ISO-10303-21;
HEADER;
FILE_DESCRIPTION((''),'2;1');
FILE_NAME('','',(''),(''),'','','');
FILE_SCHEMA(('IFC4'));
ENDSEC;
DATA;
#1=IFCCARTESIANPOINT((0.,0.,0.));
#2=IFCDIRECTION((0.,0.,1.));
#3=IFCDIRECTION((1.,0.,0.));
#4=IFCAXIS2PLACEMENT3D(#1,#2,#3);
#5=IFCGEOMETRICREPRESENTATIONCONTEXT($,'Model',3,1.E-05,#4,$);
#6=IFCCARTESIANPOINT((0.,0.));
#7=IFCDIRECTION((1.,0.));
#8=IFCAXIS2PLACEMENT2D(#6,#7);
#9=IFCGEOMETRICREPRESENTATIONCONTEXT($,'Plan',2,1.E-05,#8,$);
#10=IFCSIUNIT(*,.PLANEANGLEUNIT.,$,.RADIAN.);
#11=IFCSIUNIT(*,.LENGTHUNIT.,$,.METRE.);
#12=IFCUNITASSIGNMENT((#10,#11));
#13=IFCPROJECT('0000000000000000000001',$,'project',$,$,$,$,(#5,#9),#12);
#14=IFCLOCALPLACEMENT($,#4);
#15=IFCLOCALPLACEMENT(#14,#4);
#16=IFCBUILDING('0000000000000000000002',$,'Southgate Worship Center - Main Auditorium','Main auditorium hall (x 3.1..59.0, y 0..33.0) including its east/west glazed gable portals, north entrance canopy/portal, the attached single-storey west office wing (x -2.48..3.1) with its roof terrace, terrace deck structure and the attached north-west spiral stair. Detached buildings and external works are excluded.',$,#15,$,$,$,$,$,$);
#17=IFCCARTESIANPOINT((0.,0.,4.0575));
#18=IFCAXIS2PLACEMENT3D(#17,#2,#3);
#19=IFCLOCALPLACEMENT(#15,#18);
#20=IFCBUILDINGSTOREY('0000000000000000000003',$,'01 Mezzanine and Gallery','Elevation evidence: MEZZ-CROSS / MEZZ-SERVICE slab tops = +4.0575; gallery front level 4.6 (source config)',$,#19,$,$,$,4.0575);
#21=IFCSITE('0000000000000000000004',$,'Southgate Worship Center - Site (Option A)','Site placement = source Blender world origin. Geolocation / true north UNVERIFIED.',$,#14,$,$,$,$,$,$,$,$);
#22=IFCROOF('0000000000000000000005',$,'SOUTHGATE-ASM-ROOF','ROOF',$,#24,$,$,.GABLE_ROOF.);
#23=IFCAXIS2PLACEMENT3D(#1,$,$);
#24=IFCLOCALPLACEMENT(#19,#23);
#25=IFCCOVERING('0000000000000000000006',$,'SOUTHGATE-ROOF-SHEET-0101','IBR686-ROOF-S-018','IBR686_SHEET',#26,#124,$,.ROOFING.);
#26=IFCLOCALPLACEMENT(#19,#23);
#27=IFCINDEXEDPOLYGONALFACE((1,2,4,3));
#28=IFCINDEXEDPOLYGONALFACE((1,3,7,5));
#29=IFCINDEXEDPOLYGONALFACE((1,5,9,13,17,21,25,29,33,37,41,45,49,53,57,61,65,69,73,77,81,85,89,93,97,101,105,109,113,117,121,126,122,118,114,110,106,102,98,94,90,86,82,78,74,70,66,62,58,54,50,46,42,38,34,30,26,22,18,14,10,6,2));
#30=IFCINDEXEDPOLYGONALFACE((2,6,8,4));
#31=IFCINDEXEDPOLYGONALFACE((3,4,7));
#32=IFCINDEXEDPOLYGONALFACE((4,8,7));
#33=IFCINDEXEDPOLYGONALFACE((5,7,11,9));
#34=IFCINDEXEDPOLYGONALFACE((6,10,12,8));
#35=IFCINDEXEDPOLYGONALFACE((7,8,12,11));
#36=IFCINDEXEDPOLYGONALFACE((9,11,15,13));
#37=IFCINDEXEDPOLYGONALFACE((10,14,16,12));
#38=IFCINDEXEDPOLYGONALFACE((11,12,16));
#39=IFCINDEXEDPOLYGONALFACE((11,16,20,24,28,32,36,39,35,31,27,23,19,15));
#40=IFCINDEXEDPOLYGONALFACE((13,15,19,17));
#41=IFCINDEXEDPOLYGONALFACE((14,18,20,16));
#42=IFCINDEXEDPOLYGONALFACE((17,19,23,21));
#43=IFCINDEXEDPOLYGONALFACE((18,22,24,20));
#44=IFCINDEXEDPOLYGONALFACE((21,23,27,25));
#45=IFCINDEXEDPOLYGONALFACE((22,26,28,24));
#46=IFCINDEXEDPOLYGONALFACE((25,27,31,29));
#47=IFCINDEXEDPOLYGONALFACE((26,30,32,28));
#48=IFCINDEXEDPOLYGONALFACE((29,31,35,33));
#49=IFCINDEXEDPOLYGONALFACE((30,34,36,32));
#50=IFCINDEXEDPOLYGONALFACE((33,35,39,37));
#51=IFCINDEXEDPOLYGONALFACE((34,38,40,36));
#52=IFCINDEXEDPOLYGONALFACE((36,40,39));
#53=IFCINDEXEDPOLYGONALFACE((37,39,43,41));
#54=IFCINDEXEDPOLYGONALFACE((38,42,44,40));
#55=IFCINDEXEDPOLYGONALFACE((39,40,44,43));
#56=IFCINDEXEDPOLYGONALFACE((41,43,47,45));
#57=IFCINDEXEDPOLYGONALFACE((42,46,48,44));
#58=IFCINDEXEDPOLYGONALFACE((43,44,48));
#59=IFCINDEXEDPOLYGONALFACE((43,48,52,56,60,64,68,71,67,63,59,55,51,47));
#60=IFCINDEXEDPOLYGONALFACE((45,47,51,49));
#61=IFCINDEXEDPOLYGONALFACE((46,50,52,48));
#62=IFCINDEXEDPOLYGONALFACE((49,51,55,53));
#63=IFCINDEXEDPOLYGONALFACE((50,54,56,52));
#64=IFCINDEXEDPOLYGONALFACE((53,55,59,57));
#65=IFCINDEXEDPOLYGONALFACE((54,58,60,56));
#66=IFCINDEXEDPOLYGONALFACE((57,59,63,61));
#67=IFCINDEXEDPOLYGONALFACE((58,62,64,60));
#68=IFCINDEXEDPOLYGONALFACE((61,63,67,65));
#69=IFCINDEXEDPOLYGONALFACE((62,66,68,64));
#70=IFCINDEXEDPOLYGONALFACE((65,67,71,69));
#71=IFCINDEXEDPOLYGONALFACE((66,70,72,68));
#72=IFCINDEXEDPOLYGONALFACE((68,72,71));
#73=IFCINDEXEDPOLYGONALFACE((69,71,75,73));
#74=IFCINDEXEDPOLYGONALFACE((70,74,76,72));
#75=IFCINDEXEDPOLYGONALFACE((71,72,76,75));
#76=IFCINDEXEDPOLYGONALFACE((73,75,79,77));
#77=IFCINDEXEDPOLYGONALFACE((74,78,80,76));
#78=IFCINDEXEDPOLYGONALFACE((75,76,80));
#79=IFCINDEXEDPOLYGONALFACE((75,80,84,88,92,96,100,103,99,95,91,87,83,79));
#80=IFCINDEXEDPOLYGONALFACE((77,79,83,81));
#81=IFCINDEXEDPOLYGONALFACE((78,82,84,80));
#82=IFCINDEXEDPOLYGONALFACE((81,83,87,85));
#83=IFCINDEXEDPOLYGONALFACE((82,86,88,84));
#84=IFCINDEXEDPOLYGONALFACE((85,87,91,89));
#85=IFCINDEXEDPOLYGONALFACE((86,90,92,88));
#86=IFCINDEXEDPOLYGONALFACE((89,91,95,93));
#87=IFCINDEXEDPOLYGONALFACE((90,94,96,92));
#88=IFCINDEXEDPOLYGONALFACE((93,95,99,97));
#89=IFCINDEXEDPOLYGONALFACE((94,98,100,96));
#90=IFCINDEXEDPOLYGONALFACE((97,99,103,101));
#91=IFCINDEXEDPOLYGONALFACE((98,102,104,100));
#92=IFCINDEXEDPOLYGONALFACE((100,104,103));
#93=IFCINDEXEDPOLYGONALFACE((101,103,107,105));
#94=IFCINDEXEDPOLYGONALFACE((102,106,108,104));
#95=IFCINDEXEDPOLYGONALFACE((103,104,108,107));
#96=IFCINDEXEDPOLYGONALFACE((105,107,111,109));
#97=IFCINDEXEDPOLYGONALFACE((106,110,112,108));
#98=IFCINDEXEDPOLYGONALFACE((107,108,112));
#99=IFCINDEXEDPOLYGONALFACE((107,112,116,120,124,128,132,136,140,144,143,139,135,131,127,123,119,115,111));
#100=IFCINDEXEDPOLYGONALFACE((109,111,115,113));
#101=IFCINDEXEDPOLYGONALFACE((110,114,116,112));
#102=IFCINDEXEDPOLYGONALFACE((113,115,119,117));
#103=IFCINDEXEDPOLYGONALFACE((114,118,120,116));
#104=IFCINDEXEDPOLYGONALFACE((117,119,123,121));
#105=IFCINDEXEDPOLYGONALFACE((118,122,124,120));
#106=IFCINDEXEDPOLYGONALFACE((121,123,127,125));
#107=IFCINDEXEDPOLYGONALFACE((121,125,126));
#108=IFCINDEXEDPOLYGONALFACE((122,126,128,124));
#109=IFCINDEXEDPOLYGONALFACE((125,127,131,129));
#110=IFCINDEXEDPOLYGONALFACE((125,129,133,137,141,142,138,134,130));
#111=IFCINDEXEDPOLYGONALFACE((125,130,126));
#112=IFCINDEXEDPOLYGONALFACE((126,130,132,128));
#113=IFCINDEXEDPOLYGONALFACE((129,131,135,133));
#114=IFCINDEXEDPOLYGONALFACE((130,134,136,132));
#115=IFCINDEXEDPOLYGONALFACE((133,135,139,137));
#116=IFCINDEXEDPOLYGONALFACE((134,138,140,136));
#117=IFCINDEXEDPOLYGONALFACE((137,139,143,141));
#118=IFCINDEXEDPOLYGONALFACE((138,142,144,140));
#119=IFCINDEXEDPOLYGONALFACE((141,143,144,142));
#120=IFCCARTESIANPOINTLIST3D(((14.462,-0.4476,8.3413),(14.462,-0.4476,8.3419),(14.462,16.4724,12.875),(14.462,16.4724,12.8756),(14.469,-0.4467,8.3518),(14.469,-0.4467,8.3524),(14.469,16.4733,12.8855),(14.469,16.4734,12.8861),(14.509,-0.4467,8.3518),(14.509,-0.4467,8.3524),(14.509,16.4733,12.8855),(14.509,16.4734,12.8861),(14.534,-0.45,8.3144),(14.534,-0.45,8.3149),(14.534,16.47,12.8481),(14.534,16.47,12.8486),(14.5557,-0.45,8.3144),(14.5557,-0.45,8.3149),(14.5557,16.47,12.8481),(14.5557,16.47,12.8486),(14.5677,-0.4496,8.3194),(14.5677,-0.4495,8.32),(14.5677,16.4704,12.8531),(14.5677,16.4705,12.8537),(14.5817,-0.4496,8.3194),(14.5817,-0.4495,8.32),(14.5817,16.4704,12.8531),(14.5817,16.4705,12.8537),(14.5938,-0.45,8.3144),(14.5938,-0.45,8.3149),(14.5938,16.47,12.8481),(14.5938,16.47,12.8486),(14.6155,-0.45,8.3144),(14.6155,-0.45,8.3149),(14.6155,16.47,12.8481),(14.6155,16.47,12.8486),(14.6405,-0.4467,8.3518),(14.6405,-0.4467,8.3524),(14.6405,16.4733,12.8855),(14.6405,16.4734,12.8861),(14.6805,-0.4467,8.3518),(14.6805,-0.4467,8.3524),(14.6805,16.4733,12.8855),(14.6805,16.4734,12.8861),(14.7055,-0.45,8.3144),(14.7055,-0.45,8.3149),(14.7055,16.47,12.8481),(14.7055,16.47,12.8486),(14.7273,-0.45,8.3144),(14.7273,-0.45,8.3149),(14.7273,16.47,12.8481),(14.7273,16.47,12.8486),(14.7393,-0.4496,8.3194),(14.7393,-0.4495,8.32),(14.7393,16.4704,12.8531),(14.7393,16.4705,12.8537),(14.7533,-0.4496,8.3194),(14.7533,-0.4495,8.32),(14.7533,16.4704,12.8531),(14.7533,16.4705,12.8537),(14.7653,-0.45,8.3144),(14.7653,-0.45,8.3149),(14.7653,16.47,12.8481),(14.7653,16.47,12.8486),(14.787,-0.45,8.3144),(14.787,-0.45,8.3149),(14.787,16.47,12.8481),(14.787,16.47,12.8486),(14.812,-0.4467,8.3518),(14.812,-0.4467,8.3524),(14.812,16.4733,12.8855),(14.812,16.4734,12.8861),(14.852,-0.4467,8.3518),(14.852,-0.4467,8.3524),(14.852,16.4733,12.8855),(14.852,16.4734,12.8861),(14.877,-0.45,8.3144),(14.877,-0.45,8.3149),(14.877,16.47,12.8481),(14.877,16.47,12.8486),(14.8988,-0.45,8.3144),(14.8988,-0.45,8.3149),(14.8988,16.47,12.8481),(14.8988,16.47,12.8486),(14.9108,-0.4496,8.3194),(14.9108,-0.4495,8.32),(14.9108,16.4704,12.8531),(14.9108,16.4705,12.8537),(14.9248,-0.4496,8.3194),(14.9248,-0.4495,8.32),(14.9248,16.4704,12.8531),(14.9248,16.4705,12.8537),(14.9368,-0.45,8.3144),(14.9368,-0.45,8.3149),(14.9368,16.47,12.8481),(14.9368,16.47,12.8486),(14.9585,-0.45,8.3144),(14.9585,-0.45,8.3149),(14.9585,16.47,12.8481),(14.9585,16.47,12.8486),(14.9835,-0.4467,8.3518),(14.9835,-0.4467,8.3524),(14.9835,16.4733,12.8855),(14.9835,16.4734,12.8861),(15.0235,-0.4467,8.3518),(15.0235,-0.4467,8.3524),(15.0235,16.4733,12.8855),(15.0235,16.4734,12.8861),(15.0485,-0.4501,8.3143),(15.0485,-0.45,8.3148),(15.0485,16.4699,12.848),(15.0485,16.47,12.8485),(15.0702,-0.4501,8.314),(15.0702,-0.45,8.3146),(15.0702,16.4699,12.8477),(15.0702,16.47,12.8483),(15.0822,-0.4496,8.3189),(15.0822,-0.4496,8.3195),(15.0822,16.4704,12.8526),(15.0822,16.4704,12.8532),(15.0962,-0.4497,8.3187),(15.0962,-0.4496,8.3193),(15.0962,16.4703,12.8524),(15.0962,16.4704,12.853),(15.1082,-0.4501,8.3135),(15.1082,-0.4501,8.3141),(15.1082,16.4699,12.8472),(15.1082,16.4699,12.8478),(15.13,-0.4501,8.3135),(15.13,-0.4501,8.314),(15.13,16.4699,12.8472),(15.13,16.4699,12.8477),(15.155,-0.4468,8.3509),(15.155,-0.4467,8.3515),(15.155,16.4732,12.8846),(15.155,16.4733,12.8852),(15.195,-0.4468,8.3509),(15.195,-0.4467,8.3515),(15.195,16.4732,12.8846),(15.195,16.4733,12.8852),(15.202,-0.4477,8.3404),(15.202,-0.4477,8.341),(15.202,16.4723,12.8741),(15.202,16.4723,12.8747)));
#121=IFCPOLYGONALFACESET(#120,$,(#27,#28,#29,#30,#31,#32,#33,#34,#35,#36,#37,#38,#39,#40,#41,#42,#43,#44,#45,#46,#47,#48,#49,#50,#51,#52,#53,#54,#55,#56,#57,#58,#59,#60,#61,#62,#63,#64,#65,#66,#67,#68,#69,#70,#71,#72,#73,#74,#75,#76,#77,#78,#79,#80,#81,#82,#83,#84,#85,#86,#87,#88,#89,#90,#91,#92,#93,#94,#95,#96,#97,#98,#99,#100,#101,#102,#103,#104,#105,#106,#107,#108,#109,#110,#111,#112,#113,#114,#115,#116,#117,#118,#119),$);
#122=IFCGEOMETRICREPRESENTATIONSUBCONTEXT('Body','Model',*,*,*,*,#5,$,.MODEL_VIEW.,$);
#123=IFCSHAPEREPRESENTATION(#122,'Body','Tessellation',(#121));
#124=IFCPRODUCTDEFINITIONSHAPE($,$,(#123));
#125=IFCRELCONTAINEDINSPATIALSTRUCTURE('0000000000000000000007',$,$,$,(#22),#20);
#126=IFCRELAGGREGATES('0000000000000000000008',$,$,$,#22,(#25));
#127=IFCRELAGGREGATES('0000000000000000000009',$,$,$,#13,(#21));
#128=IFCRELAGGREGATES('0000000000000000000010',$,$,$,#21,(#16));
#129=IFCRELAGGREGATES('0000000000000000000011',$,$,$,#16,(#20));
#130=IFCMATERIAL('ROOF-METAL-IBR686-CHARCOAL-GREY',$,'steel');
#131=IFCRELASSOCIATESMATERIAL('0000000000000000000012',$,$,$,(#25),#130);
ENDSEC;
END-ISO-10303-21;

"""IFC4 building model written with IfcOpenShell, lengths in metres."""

from ifc_helpers import new_model, si_unit, frame, origin_with_axes, origin_2d_with_axis, place, context, subcontext, project, spatial, indexed_curve, outline, extrude, clip, halfspace, material, element, aggregate, save


model = new_model("IFC4")

# Units and contexts
model_context = context("Model", 3, precision=1e-05, world=origin_with_axes())
plan_context = context("Plan", 2, precision=1e-05, world=origin_2d_with_axis())
body_context = subcontext(model_context, "Body", "Model", "MODEL_VIEW")
ifc_project = project(units=[si_unit("PLANEANGLEUNIT", "RADIAN"), si_unit("LENGTHUNIT", "METRE")], contexts=[model_context, plan_context])

# Site, building, storey
site_placement = place(None, origin_with_axes())
site = spatial("IfcSite", under=ifc_project, at=site_placement, Name="Southgate Worship Center - Site (Option A)", Description="Site placement = source Blender world origin. Geolocation / true north UNVERIFIED.")
building_placement = place(site_placement, origin_with_axes())
building = spatial("IfcBuilding", under=site, at=building_placement, Name="Southgate Worship Center - Main Auditorium", Description="Main auditorium hall (x 3.1..59.0, y 0..33.0) including its east/west glazed gable portals, north entrance canopy/portal, the attached single-storey west office wing (x -2.48..3.1) with its roof terrace, terrace deck structure and the attached north-west spiral stair. Detached buildings and external works are excluded.")
storey_placement = place(building_placement, frame((0.0, 0.0, 4.0575), z_axis=(0.0, 0.0, 1.0), x_axis=(1.0, 0.0, 0.0)))
storey = spatial("IfcBuildingStorey", under=building, at=storey_placement, Name="01 Mezzanine and Gallery", Description="Elevation evidence: MEZZ-CROSS / MEZZ-SERVICE slab tops = +4.0575; gallery front level 4.6 (source config)", Elevation=4.0575)

# Roof, covering
roof_placement = place(storey_placement, origin_with_axes())
roof = element("IfcRoof", 1, at=roof_placement, inside=storey, Name="SOUTHGATE-ASM-ROOF", Description="ROOF", PredefinedType="GABLE_ROOF")
ifc_material_1 = material(Name="ROOF-METAL-IBR686-CHARCOAL-GREY", Category="steel")
covering_1_placement = place(roof_placement, frame((14.462, -0.4501, 8.3135), z_axis=(0.0, 0.0, 1.0), x_axis=(1.0, 0.0, 0.0)))
covering_1 = element("IfcCovering", 2, at=covering_1_placement, material=ifc_material_1, Name="SOUTHGATE-ROOF-SHEET-0101", Description="IBR686-ROOF-S-018", ObjectType="IBR686_SHEET", PredefinedType="ROOFING", context=body_context, shape_type="Clipping", body=[
    clip(clip(extrude(outline(indexed_curve([(0.0, 0.0), (0.025, 0.0353), (0.065, 0.0353), (0.072, 0.0254), (0.072, 0.0259), (0.065, 0.0358), (0.025, 0.0358), (0.0, 0.0005), (-0.0217, 0.0005), (-0.0337, 0.0053), (-0.0477, 0.0053), (-0.0597, 0.0005), (-0.0815, 0.0005), (-0.1065, 0.0358), (-0.1465, 0.0358), (-0.1715, 0.0005), (-0.1932, 0.0005), (-0.2052, 0.0053), (-0.2192, 0.0053), (-0.2312, 0.0005), (-0.253, 0.0005), (-0.278, 0.0358), (-0.318, 0.0358), (-0.343, 0.0005), (-0.3647, 0.0005), (-0.3767, 0.0053), (-0.3907, 0.0053), (-0.4028, 0.0005), (-0.4245, 0.0005), (-0.4495, 0.0358), (-0.4895, 0.0358), (-0.5145, 0.0004), (-0.5362, 0.0002), (-0.5482, 0.0048), (-0.5622, 0.0046), (-0.5742, -0.0003), (-0.596, -0.0004), (-0.621, 0.0349), (-0.661, 0.0349), (-0.668, 0.0251), (-0.668, 0.0246), (-0.661, 0.0344), (-0.621, 0.0344), (-0.596, -0.0009), (-0.5742, -0.0008), (-0.5622, 0.0041), (-0.5482, 0.0043), (-0.5362, -0.0003), (-0.5145, -0.0001), (-0.4895, 0.0353), (-0.4495, 0.0353), (-0.4245, 0.0), (-0.4028, 0.0), (-0.3907, 0.0048), (-0.3767, 0.0048), (-0.3647, 0.0), (-0.343, 0.0), (-0.318, 0.0353), (-0.278, 0.0353), (-0.253, 0.0), (-0.2312, 0.0), (-0.2192, 0.0048), (-0.2052, 0.0048), (-0.1932, 0.0), (-0.1715, 0.0), (-0.1465, 0.0353), (-0.1065, 0.0353), (-0.0815, 0.0), (-0.0597, 0.0), (-0.0477, 0.0048), (-0.0337, 0.0048), (-0.0217, 0.0), (0.0, 0.0)], self_intersect=False)), frame((0.072, -0.0003, 0.0008), z_axis=(0.0, 0.965926, 0.258819), x_axis=(-1.0, 0.0, 0.0)), (0.0, 0.0, 1.0), 17.5303), halfspace(frame((0.37, 0.0012, 0.014), z_axis=(0.0, -0.996022, 0.089113), x_axis=(1.0, 0.0, 0.0)), False)), halfspace(frame((0.37, 16.9212, 4.5477), z_axis=(0.0, 0.996021, -0.089119), x_axis=(-1.0, 0.0, 0.0)), False)),
])
aggregate(roof, [covering_1])

save(model, "model.ifc")
